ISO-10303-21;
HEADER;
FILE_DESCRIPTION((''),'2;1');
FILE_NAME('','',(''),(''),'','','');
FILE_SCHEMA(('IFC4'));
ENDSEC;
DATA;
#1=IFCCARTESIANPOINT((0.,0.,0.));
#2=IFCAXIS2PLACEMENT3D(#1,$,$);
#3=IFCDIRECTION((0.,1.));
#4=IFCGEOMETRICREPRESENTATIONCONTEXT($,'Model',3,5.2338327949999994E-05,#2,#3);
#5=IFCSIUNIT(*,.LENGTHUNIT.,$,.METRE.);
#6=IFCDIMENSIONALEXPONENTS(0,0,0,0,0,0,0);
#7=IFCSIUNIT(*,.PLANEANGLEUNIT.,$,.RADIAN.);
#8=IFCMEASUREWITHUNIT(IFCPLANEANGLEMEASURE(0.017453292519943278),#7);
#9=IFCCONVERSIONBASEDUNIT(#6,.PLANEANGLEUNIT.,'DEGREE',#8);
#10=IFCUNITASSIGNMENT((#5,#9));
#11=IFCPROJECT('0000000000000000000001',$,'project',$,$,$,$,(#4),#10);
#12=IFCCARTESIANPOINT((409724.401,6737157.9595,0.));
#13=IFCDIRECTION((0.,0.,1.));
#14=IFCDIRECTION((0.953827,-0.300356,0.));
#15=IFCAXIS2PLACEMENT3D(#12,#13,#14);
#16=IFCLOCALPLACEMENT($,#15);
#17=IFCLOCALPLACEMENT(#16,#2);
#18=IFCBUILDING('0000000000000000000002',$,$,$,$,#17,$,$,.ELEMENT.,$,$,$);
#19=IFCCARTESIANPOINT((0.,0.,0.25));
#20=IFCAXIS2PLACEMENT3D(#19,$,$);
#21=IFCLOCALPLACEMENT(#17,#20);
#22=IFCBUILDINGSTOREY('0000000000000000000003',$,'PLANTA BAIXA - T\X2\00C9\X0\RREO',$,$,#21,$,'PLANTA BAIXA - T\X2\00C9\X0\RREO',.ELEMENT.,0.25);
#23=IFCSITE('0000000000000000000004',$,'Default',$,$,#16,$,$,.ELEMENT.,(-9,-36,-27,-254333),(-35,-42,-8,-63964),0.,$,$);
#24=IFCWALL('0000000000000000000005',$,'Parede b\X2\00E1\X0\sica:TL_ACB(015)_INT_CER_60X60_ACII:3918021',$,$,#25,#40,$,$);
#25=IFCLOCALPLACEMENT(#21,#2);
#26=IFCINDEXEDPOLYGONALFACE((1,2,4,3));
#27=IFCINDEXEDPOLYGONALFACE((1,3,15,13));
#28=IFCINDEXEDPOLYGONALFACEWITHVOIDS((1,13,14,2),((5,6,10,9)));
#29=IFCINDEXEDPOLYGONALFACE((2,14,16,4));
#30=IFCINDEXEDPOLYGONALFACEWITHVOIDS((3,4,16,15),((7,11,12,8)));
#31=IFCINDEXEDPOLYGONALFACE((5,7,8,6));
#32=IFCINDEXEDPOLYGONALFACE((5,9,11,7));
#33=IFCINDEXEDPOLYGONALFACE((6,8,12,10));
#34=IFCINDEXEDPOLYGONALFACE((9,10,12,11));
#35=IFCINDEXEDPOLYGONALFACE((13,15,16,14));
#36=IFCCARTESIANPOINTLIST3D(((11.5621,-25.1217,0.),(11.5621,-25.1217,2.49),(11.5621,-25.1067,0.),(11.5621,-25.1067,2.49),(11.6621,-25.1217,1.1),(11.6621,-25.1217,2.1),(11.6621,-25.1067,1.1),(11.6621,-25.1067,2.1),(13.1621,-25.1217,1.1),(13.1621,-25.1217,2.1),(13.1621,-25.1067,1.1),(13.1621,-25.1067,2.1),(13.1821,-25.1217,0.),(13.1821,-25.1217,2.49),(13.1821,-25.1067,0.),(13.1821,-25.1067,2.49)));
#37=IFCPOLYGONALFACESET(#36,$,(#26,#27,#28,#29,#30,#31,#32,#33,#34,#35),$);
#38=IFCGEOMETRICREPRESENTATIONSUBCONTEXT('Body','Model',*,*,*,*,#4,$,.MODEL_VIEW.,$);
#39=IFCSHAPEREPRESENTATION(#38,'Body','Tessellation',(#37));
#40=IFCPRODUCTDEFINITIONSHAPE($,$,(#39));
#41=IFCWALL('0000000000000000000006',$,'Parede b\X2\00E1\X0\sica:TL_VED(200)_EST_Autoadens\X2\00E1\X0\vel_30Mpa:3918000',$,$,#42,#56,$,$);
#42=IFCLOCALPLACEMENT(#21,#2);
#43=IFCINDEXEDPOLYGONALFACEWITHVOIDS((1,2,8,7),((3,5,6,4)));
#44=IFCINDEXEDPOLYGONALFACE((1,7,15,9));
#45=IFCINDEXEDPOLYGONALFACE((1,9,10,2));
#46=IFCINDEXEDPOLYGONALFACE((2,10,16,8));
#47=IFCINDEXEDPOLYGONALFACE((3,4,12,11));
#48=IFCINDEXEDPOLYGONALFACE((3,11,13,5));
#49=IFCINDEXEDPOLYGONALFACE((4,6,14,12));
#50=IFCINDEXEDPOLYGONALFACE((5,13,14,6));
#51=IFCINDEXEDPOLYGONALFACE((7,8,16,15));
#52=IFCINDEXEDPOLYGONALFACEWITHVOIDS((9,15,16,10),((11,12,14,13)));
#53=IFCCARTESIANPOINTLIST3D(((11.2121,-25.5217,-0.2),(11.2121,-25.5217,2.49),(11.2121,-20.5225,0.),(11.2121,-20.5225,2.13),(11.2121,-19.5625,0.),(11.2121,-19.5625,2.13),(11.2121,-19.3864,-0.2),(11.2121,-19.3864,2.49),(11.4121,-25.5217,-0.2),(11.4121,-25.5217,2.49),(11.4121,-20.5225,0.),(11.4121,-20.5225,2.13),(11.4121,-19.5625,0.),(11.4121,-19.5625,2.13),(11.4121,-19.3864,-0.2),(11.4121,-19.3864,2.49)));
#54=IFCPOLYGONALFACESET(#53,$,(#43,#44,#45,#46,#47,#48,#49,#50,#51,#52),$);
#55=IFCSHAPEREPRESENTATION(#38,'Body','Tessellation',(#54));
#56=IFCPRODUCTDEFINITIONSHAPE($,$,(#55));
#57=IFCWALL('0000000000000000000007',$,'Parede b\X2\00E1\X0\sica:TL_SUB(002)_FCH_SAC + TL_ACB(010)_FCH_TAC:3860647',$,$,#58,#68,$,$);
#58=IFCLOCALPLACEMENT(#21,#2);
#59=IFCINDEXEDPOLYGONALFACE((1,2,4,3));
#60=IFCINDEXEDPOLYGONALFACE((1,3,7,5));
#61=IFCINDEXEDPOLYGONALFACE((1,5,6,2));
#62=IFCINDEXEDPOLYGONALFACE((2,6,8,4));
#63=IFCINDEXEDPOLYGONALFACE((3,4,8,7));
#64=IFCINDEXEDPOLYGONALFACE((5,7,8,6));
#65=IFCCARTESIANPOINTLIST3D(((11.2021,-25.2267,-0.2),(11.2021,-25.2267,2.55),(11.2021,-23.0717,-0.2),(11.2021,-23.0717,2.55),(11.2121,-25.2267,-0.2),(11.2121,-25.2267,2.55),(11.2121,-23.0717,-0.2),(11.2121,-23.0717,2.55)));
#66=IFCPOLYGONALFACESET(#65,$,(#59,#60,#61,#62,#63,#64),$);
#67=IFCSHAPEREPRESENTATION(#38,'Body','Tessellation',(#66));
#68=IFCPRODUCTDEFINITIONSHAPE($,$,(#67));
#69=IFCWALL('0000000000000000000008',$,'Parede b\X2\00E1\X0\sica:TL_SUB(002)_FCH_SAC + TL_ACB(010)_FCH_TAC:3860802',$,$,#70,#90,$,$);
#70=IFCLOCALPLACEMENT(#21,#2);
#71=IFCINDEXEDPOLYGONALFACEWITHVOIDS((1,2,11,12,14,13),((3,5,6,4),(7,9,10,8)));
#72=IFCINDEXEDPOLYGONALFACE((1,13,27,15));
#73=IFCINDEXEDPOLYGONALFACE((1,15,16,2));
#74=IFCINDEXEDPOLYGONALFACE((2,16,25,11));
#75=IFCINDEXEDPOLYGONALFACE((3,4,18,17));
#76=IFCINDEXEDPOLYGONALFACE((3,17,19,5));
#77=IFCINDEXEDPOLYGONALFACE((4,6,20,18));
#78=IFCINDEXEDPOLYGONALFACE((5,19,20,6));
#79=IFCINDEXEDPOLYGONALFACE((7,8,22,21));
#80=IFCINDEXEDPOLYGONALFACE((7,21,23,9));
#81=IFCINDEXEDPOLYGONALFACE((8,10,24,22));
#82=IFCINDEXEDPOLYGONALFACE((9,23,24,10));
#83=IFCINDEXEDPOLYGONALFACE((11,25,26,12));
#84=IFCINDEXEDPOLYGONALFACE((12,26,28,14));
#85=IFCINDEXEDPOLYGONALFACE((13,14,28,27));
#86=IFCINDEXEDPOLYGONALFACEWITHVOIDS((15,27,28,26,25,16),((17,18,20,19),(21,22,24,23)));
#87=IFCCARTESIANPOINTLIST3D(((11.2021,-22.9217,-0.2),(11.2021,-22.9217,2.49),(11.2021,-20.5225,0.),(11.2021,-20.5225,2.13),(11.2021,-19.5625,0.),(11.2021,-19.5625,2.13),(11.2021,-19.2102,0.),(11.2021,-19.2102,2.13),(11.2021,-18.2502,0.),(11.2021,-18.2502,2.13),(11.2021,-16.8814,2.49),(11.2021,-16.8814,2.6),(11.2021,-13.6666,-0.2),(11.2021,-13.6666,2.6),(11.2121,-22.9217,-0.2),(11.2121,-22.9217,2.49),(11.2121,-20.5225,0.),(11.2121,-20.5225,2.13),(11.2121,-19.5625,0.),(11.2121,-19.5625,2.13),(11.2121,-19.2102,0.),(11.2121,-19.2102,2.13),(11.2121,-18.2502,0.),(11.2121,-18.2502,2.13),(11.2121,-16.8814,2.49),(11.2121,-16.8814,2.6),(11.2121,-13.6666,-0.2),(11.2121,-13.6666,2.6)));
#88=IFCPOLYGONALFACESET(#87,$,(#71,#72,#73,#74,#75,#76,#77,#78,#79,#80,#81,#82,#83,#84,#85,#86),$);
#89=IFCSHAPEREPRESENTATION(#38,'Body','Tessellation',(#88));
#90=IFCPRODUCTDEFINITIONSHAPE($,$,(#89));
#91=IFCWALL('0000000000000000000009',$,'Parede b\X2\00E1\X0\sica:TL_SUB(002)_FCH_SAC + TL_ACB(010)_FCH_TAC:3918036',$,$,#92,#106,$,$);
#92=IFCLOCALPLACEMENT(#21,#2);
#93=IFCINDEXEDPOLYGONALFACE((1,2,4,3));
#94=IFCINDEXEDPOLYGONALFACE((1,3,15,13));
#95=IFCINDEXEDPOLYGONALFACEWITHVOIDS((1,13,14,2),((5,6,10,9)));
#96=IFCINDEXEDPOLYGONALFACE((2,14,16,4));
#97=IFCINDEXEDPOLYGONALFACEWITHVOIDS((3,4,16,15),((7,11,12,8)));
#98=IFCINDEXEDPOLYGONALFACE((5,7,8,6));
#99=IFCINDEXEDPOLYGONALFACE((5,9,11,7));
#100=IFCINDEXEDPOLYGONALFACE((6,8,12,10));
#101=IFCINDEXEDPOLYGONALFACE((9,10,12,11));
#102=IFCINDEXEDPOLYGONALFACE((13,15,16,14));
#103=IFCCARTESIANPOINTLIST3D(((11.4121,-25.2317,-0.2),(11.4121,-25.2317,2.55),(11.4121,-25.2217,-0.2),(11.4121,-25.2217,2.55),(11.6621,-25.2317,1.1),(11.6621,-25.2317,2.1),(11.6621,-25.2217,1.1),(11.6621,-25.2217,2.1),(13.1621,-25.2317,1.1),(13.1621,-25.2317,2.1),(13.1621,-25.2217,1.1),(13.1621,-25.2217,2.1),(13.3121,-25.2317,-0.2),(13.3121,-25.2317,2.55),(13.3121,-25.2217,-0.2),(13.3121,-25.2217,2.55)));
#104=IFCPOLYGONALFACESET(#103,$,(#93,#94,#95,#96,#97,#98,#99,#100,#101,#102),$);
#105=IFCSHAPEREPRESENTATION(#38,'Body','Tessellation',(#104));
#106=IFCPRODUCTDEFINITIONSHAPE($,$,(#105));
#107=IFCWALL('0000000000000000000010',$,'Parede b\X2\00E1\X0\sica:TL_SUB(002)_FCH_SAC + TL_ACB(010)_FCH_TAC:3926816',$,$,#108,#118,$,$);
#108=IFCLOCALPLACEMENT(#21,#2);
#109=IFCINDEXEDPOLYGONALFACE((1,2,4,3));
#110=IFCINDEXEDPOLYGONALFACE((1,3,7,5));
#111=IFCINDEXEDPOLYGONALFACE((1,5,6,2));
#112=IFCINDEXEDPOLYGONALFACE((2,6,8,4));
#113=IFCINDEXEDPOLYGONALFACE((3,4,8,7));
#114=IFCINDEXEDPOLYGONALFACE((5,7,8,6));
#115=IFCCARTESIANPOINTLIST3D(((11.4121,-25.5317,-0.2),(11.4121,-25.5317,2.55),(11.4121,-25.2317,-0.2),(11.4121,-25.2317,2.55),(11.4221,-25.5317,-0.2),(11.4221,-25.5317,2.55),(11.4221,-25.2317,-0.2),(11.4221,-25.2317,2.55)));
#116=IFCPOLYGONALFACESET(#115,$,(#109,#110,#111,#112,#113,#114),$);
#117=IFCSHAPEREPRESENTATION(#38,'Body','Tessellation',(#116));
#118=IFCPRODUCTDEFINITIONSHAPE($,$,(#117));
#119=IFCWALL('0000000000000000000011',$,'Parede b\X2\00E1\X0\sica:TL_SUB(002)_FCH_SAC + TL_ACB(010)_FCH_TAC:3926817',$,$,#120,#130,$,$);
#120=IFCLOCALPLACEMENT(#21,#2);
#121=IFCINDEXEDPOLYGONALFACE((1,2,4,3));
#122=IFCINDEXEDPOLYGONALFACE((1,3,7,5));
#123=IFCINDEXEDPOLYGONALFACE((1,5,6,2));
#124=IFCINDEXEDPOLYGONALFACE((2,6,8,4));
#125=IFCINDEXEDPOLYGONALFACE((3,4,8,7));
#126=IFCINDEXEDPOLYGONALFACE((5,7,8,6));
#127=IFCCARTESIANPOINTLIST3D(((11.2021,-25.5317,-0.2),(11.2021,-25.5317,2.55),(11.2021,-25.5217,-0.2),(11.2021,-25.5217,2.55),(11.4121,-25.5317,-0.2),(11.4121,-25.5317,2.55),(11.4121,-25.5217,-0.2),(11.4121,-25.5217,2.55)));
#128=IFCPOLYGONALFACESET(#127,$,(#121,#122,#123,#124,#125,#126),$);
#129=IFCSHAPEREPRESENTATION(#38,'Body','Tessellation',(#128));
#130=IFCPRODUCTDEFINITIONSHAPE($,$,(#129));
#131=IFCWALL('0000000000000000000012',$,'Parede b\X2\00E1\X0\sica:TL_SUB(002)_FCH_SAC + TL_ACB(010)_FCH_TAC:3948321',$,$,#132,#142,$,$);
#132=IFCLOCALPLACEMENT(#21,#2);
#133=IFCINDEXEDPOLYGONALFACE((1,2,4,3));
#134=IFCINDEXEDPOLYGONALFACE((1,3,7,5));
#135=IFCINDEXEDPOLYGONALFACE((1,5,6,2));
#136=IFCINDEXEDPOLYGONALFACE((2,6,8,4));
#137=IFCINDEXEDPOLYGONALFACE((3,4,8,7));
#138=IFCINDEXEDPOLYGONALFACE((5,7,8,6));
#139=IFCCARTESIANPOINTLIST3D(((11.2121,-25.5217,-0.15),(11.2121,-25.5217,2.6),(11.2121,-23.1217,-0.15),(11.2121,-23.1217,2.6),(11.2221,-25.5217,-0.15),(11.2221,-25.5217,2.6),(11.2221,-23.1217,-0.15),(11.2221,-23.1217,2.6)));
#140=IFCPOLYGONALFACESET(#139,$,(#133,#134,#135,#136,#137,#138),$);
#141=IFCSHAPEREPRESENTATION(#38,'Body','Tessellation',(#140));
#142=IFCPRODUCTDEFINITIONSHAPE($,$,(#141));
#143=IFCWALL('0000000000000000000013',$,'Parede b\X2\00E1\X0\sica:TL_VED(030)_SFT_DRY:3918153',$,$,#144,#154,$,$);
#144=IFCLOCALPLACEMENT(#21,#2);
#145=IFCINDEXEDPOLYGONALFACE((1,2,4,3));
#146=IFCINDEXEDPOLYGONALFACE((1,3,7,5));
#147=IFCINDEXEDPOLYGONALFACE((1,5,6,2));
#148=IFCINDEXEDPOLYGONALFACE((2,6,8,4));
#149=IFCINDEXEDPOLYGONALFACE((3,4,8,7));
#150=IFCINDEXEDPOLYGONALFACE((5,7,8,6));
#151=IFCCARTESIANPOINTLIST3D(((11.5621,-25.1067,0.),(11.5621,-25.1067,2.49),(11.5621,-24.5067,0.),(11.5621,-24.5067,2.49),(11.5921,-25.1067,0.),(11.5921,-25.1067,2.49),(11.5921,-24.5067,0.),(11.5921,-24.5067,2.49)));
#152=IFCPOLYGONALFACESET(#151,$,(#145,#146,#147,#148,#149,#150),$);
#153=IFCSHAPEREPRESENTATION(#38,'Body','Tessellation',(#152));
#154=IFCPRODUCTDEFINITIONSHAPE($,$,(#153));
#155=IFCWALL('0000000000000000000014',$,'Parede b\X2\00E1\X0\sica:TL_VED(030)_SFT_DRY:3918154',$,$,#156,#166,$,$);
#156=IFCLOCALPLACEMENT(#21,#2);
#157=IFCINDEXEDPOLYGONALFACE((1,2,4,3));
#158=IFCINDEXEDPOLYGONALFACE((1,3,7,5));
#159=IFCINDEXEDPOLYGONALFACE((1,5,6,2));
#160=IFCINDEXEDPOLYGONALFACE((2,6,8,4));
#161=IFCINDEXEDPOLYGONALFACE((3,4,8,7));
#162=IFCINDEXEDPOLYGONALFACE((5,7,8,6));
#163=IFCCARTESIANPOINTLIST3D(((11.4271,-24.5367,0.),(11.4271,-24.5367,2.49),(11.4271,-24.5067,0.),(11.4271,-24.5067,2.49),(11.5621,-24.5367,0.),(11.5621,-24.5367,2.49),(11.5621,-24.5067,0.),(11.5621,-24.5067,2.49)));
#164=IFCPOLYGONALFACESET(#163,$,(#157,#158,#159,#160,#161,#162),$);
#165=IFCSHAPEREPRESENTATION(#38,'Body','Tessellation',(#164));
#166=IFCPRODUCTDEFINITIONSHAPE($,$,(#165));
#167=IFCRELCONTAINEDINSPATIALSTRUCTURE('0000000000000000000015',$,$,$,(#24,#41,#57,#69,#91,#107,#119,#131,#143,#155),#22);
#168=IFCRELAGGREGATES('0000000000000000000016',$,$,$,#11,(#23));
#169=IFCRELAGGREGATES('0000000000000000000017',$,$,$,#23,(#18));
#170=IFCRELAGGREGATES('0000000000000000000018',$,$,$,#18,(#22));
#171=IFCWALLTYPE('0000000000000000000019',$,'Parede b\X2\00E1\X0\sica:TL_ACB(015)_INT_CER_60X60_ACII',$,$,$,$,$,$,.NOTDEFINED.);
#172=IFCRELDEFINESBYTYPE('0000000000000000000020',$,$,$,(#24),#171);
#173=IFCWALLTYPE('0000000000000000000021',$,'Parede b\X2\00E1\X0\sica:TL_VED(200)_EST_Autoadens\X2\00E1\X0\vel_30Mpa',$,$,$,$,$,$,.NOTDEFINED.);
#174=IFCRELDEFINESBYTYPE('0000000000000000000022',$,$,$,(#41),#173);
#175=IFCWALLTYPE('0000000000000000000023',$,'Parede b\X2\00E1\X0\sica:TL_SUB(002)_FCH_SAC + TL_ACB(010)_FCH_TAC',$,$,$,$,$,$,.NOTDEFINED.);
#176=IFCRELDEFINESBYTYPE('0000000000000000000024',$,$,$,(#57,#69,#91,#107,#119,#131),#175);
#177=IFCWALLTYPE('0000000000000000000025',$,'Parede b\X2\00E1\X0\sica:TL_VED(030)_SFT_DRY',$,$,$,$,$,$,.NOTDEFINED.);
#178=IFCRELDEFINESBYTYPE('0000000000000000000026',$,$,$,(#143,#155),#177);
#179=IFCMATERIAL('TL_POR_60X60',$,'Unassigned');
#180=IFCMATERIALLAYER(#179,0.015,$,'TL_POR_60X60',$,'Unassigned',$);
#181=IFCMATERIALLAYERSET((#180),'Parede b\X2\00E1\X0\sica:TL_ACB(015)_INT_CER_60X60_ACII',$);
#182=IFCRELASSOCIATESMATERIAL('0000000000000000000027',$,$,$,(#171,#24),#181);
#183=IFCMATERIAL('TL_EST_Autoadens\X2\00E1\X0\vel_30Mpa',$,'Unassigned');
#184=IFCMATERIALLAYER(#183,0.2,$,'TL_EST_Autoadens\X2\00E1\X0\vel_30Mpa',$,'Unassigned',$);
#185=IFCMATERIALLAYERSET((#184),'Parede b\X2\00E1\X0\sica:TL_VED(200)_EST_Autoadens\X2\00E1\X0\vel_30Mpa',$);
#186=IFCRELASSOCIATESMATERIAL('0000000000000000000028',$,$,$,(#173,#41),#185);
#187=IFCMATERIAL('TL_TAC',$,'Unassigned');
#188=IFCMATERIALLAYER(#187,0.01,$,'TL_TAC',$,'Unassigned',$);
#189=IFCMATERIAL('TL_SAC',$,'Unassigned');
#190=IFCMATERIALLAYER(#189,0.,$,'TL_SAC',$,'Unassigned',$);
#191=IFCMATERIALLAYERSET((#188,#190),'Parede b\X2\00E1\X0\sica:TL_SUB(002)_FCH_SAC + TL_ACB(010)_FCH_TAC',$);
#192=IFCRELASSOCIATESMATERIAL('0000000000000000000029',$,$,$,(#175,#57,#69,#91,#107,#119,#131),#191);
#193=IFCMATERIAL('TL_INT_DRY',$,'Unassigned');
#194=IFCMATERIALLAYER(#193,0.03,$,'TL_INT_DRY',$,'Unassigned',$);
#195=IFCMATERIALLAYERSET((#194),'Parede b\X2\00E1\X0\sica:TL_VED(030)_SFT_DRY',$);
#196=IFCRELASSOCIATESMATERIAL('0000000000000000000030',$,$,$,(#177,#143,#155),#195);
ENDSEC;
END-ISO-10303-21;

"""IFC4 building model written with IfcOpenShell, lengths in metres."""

from ifc_helpers import new_model, entity, si_unit, converted_unit, direction, frame, frame_2d, origin, place, context, subcontext, project, spatial, polyline, rectangle, extrude, clip, bounded_halfspace, material, layer, layer_set, layer_usage, type_object, element, save


model = new_model("IFC4")

# Units and contexts
model_context = context("Model", 3, precision=5.2338327949999994e-05, world=origin(), true_north=direction((0.0, 1.0)))
body_context = subcontext(model_context, "Body", "Model", "MODEL_VIEW")
ifc_project = project(units=[si_unit("LENGTHUNIT", "METRE"), converted_unit("PLANEANGLEUNIT", "DEGREE", entity("IfcPlaneAngleMeasure", 0.017453292519943278), si_unit("PLANEANGLEUNIT", "RADIAN"), dimensions=[0, 0, 0, 0, 0, 0, 0])], contexts=[model_context])

# Site, building, storey
site_placement = place(None, frame((409724.401, 6737157.9595, 0.0), z_axis=(0.0, 0.0, 1.0), x_axis=(0.953827, -0.300356, 0.0)))
site = spatial("IfcSite", under=ifc_project, at=site_placement, Name="Default", CompositionType="ELEMENT", RefLatitude=(-9, -36, -27, -254333), RefLongitude=(-35, -42, -8, -63964), RefElevation=0.0)
building_placement = place(site_placement, origin())
building = spatial("IfcBuilding", under=site, at=building_placement, CompositionType="ELEMENT")
storey_placement = place(building_placement, frame((0.0, 0.0, 0.25)))
storey = spatial("IfcBuildingStorey", under=building, at=storey_placement, Name="PLANTA BAIXA - TÉRREO", LongName="PLANTA BAIXA - TÉRREO", CompositionType="ELEMENT", Elevation=0.25)

# Shared definitions
ifc_material_1 = material(Name="TL_POR_60X60", Category="Unassigned")

# Shared definitions
ifc_material_2 = material(Name="TL_EST_Autoadensável_30Mpa", Category="Unassigned")

# Shared definitions
ifc_layer_1 = layer(ifc_material_1, 0.015, Name="TL_POR_60X60", Category="Unassigned")
ifc_layer_set_1 = layer_set([ifc_layer_1], Name="Parede básica:TL_ACB(015)_INT_CER_60X60_ACII")
wall_type_1 = type_object("IfcWallType", Name="Parede básica:TL_ACB(015)_INT_CER_60X60_ACII", PredefinedType="NOTDEFINED", material=ifc_layer_set_1)

# Walls, openings
ifc_layer_usage_1 = layer_usage(ifc_layer_set_1, "AXIS2", "NEGATIVE", 0.0075)
wall_1_placement = place(storey_placement, frame((11.5621, -25.1142, 0.0)))
wall_1 = element("IfcWall", 1, at=wall_1_placement, inside=storey, type_object=wall_type_1, material=ifc_layer_usage_1, Name="Parede básica:TL_ACB(015)_INT_CER_60X60_ACII:3918021", context=body_context, shape_type="SweptSolid", body=[
    extrude(rectangle(XDim=1.62, YDim=0.015, at=frame_2d((0.81, 0.0), x_axis=(-1.0, 0.0))), origin(), (0.0, 0.0, 1.0), 2.49),
])
opening_1_placement = place(wall_1_placement, frame((-11.5621, 25.1142, 1.1)))
element("IfcOpeningElement", 2, at=opening_1_placement, cuts=wall_1, PredefinedType="OPENING", context=body_context, shape_type="SweptSolid", body=[
    extrude(rectangle(XDim=1.0, YDim=1.5, at=frame_2d((0.0, 0.0), x_axis=(0.0, 1.0))), frame((12.4121, -26.6457, 0.5), z_axis=(0.0, 1.0, 0.0), x_axis=(1.0, 0.0, 0.0)), (0.0, 0.0, 1.0), 3.048),
])
ifc_layer_2 = layer(ifc_material_2, 0.2, Name="TL_EST_Autoadensável_30Mpa", Category="Unassigned")
ifc_layer_set_2 = layer_set([ifc_layer_2], Name="Parede básica:TL_VED(200)_EST_Autoadensável_30Mpa")
ifc_layer_usage_2 = layer_usage(ifc_layer_set_2, "AXIS2", "NEGATIVE", 0.1)
wall_type_2 = type_object("IfcWallType", Name="Parede básica:TL_VED(200)_EST_Autoadensável_30Mpa", PredefinedType="NOTDEFINED", material=ifc_layer_set_2)
wall_2_placement = place(storey_placement, frame((11.3121, -25.5217, -0.2), z_axis=(0.0, 0.0, 1.0), x_axis=(0.0, 1.0, 0.0)))
wall_2 = element("IfcWall", 3, at=wall_2_placement, inside=storey, type_object=wall_type_2, material=ifc_layer_usage_2, Name="Parede básica:TL_VED(200)_EST_Autoadensável_30Mpa:3918000", context=body_context, shape_type="SweptSolid", body=[
    extrude(rectangle(XDim=6.1354, YDim=0.2, at=frame_2d((3.0677, 0.0), x_axis=(-1.0, 0.0))), origin(), (0.0, 0.0, 1.0), 2.69),
])
opening_2_placement = place(wall_2_placement, frame((5.9592, 0.1, 0.2)))
element("IfcOpeningElement", 4, at=opening_2_placement, cuts=wall_2, PredefinedType="OPENING", context=body_context, shape_type="SweptSolid", body=[
    extrude(rectangle(XDim=2.13, YDim=0.96, at=frame_2d((1.065, 0.48), x_axis=(1.0, 0.0))), frame((0.0, 0.0, 0.0), z_axis=(0.0, -1.0, 0.0), x_axis=(0.0, 0.0, 1.0)), (0.0, 0.0, 1.0), 0.2),
])

# Wall
ifc_material_3 = material(Name="TL_TAC", Category="Unassigned")
ifc_layer_3 = layer(ifc_material_3, 0.01, Name="TL_TAC", Category="Unassigned")
ifc_material_4 = material(Name="TL_SAC", Category="Unassigned")
ifc_layer_4 = layer(ifc_material_4, 0.0, Name="TL_SAC", Category="Unassigned")
ifc_layer_set_3 = layer_set([ifc_layer_3, ifc_layer_4], Name="Parede básica:TL_SUB(002)_FCH_SAC + TL_ACB(010)_FCH_TAC")
ifc_layer_usage_3 = layer_usage(ifc_layer_set_3, "AXIS2", "NEGATIVE", 0.005)
wall_type_3 = type_object("IfcWallType", Name="Parede básica:TL_SUB(002)_FCH_SAC + TL_ACB(010)_FCH_TAC", PredefinedType="NOTDEFINED", material=ifc_layer_set_3)
wall_3_placement = place(storey_placement, frame((11.2071, -23.0717, -0.2), z_axis=(0.0, 0.0, 1.0), x_axis=(0.0, -1.0, 0.0)))
element("IfcWall", 5, at=wall_3_placement, inside=storey, type_object=wall_type_3, material=ifc_layer_usage_3, Name="Parede básica:TL_SUB(002)_FCH_SAC + TL_ACB(010)_FCH_TAC:3860647", context=body_context, shape_type="SweptSolid", body=[
    extrude(rectangle(XDim=2.155, YDim=0.01, at=frame_2d((1.0775, 0.0), x_axis=(-1.0, 0.0))), origin(), (0.0, 0.0, 1.0), 2.75),
])

# Wall, openings
ifc_layer_usage_4 = layer_usage(ifc_layer_set_3, "AXIS2", "POSITIVE", -0.005)
wall_4_placement = place(storey_placement, frame((11.2071, -22.9217, -0.2), z_axis=(0.0, 0.0, 1.0), x_axis=(0.0, 1.0, 0.0)))
wall_4 = element("IfcWall", 6, at=wall_4_placement, inside=storey, type_object=wall_type_3, material=ifc_layer_usage_4, Name="Parede básica:TL_SUB(002)_FCH_SAC + TL_ACB(010)_FCH_TAC:3860802", context=body_context, shape_type="Clipping", body=[
    clip(extrude(rectangle(XDim=9.2551, YDim=0.01, at=frame_2d((4.6276, 0.0), x_axis=(-1.0, 0.0))), origin(), (0.0, 0.0, 1.0), 2.8), bounded_halfspace(frame((0.0, -0.005, 2.69), z_axis=(0.0, 0.0, -1.0), x_axis=(-1.0, 0.0, 0.0)), True, frame((0.0, -0.005, 2.69)), polyline([(0.0, 0.0), (3.5354, 0.0), (6.0403, 0.0), (6.0403, 0.01), (0.01, 0.01), (0.0, 0.01), (0.0, 0.0)]))),
])
opening_3_placement = place(wall_4_placement, frame((22.9217, 11.2071, 0.2)))
element("IfcOpeningElement", 7, at=opening_3_placement, cuts=wall_4, PredefinedType="OPENING", context=body_context, shape_type="SweptSolid", body=[
    extrude(rectangle(XDim=2.13, YDim=0.96, at=frame_2d((0.0, 0.0), x_axis=(0.0, 1.0))), frame((-18.7302, -12.9361, 1.065), z_axis=(0.0, 1.0, 0.0), x_axis=(-1.0, 0.0, 0.0)), (0.0, 0.0, 1.0), 3.048),
])
opening_4_placement = place(wall_4_placement, frame((22.9217, 11.2071, 0.2)))
element("IfcOpeningElement", 8, at=opening_4_placement, cuts=wall_4, PredefinedType="OPENING", context=body_context, shape_type="SweptSolid", body=[
    extrude(rectangle(XDim=2.13, YDim=0.96, at=frame_2d((0.0, 0.0), x_axis=(1.0, 0.0))), frame((-20.0425, -12.9361, 1.065), z_axis=(0.0, 1.0, 0.0), x_axis=(0.0, 0.0, 1.0)), (0.0, 0.0, 1.0), 3.048),
])

# Wall, opening
ifc_layer_usage_5 = layer_usage(ifc_layer_set_3, "AXIS2", "NEGATIVE", 0.005)
wall_5_placement = place(storey_placement, frame((11.4121, -25.2267, -0.2)))
wall_5 = element("IfcWall", 9, at=wall_5_placement, inside=storey, type_object=wall_type_3, material=ifc_layer_usage_5, Name="Parede básica:TL_SUB(002)_FCH_SAC + TL_ACB(010)_FCH_TAC:3918036", context=body_context, shape_type="SweptSolid", body=[
    extrude(rectangle(XDim=1.9, YDim=0.01, at=frame_2d((0.95, 0.0), x_axis=(-1.0, 0.0))), origin(), (0.0, 0.0, 1.0), 2.75),
])
opening_5_placement = place(wall_5_placement, frame((-11.4121, 25.2267, 1.3)))
element("IfcOpeningElement", 10, at=opening_5_placement, cuts=wall_5, PredefinedType="OPENING", context=body_context, shape_type="SweptSolid", body=[
    extrude(rectangle(XDim=1.0, YDim=1.5, at=frame_2d((0.0, 0.0), x_axis=(0.0, 1.0))), frame((12.4121, -26.6457, 0.5), z_axis=(0.0, 1.0, 0.0), x_axis=(1.0, 0.0, 0.0)), (0.0, 0.0, 1.0), 3.048),
])

# Walls
ifc_layer_usage_6 = layer_usage(ifc_layer_set_3, "AXIS2", "POSITIVE", -0.005)
wall_6_placement = place(storey_placement, frame((11.4171, -25.2317, -0.2), z_axis=(0.0, 0.0, 1.0), x_axis=(0.0, -1.0, 0.0)))
element("IfcWall", 11, at=wall_6_placement, inside=storey, type_object=wall_type_3, material=ifc_layer_usage_6, Name="Parede básica:TL_SUB(002)_FCH_SAC + TL_ACB(010)_FCH_TAC:3926816", context=body_context, shape_type="SweptSolid", body=[
    extrude(rectangle(XDim=0.3, YDim=0.01, at=frame_2d((0.15, 0.0), x_axis=(-1.0, 0.0))), origin(), (0.0, 0.0, 1.0), 2.75),
])
ifc_layer_usage_7 = layer_usage(ifc_layer_set_3, "AXIS2", "POSITIVE", -0.005)
wall_7_placement = place(storey_placement, frame((11.4121, -25.5267, -0.2), z_axis=(0.0, 0.0, 1.0), x_axis=(-1.0, 0.0, 0.0)))
element("IfcWall", 12, at=wall_7_placement, inside=storey, type_object=wall_type_3, material=ifc_layer_usage_7, Name="Parede básica:TL_SUB(002)_FCH_SAC + TL_ACB(010)_FCH_TAC:3926817", context=body_context, shape_type="SweptSolid", body=[
    extrude(rectangle(XDim=0.21, YDim=0.01, at=frame_2d((0.105, 0.0), x_axis=(-1.0, 0.0))), origin(), (0.0, 0.0, 1.0), 2.75),
])
ifc_layer_usage_8 = layer_usage(ifc_layer_set_3, "AXIS2", "NEGATIVE", 0.005)
wall_8_placement = place(storey_placement, frame((11.2171, -25.5217, -0.15), z_axis=(0.0, 0.0, 1.0), x_axis=(0.0, 1.0, 0.0)))
element("IfcWall", 13, at=wall_8_placement, inside=storey, type_object=wall_type_3, material=ifc_layer_usage_8, Name="Parede básica:TL_SUB(002)_FCH_SAC + TL_ACB(010)_FCH_TAC:3948321", context=body_context, shape_type="SweptSolid", body=[
    extrude(rectangle(XDim=2.4, YDim=0.01, at=frame_2d((1.2, 0.0), x_axis=(-1.0, 0.0))), origin(), (0.0, 0.0, 1.0), 2.75),
])
ifc_material_5 = material(Name="TL_INT_DRY", Category="Unassigned")
ifc_layer_5 = layer(ifc_material_5, 0.03, Name="TL_INT_DRY", Category="Unassigned")
ifc_layer_set_4 = layer_set([ifc_layer_5], Name="Parede básica:TL_VED(030)_SFT_DRY")
ifc_layer_usage_9 = layer_usage(ifc_layer_set_4, "AXIS2", "POSITIVE", -0.015)
wall_type_4 = type_object("IfcWallType", Name="Parede básica:TL_VED(030)_SFT_DRY", PredefinedType="NOTDEFINED", material=ifc_layer_set_4)
wall_9_placement = place(storey_placement, frame((11.5771, -25.1067, 0.0), z_axis=(0.0, 0.0, 1.0), x_axis=(0.0, 1.0, 0.0)))
element("IfcWall", 14, at=wall_9_placement, inside=storey, type_object=wall_type_4, material=ifc_layer_usage_9, Name="Parede básica:TL_VED(030)_SFT_DRY:3918153", context=body_context, shape_type="SweptSolid", body=[
    extrude(rectangle(XDim=0.6, YDim=0.03, at=frame_2d((0.3, 0.0), x_axis=(-1.0, 0.0))), origin(), (0.0, 0.0, 1.0), 2.49),
])
ifc_layer_usage_10 = layer_usage(ifc_layer_set_4, "AXIS2", "POSITIVE", -0.015)
wall_10_placement = place(storey_placement, frame((11.5621, -24.5217, 0.0), z_axis=(0.0, 0.0, 1.0), x_axis=(-1.0, 0.0, 0.0)))
element("IfcWall", 15, at=wall_10_placement, inside=storey, type_object=wall_type_4, material=ifc_layer_usage_10, Name="Parede básica:TL_VED(030)_SFT_DRY:3918154", context=body_context, shape_type="SweptSolid", body=[
    extrude(rectangle(XDim=0.135, YDim=0.03, at=frame_2d((0.0675, 0.0), x_axis=(-1.0, 0.0))), origin(), (0.0, 0.0, 1.0), 2.49),
])

save(model, "model.ifc")
